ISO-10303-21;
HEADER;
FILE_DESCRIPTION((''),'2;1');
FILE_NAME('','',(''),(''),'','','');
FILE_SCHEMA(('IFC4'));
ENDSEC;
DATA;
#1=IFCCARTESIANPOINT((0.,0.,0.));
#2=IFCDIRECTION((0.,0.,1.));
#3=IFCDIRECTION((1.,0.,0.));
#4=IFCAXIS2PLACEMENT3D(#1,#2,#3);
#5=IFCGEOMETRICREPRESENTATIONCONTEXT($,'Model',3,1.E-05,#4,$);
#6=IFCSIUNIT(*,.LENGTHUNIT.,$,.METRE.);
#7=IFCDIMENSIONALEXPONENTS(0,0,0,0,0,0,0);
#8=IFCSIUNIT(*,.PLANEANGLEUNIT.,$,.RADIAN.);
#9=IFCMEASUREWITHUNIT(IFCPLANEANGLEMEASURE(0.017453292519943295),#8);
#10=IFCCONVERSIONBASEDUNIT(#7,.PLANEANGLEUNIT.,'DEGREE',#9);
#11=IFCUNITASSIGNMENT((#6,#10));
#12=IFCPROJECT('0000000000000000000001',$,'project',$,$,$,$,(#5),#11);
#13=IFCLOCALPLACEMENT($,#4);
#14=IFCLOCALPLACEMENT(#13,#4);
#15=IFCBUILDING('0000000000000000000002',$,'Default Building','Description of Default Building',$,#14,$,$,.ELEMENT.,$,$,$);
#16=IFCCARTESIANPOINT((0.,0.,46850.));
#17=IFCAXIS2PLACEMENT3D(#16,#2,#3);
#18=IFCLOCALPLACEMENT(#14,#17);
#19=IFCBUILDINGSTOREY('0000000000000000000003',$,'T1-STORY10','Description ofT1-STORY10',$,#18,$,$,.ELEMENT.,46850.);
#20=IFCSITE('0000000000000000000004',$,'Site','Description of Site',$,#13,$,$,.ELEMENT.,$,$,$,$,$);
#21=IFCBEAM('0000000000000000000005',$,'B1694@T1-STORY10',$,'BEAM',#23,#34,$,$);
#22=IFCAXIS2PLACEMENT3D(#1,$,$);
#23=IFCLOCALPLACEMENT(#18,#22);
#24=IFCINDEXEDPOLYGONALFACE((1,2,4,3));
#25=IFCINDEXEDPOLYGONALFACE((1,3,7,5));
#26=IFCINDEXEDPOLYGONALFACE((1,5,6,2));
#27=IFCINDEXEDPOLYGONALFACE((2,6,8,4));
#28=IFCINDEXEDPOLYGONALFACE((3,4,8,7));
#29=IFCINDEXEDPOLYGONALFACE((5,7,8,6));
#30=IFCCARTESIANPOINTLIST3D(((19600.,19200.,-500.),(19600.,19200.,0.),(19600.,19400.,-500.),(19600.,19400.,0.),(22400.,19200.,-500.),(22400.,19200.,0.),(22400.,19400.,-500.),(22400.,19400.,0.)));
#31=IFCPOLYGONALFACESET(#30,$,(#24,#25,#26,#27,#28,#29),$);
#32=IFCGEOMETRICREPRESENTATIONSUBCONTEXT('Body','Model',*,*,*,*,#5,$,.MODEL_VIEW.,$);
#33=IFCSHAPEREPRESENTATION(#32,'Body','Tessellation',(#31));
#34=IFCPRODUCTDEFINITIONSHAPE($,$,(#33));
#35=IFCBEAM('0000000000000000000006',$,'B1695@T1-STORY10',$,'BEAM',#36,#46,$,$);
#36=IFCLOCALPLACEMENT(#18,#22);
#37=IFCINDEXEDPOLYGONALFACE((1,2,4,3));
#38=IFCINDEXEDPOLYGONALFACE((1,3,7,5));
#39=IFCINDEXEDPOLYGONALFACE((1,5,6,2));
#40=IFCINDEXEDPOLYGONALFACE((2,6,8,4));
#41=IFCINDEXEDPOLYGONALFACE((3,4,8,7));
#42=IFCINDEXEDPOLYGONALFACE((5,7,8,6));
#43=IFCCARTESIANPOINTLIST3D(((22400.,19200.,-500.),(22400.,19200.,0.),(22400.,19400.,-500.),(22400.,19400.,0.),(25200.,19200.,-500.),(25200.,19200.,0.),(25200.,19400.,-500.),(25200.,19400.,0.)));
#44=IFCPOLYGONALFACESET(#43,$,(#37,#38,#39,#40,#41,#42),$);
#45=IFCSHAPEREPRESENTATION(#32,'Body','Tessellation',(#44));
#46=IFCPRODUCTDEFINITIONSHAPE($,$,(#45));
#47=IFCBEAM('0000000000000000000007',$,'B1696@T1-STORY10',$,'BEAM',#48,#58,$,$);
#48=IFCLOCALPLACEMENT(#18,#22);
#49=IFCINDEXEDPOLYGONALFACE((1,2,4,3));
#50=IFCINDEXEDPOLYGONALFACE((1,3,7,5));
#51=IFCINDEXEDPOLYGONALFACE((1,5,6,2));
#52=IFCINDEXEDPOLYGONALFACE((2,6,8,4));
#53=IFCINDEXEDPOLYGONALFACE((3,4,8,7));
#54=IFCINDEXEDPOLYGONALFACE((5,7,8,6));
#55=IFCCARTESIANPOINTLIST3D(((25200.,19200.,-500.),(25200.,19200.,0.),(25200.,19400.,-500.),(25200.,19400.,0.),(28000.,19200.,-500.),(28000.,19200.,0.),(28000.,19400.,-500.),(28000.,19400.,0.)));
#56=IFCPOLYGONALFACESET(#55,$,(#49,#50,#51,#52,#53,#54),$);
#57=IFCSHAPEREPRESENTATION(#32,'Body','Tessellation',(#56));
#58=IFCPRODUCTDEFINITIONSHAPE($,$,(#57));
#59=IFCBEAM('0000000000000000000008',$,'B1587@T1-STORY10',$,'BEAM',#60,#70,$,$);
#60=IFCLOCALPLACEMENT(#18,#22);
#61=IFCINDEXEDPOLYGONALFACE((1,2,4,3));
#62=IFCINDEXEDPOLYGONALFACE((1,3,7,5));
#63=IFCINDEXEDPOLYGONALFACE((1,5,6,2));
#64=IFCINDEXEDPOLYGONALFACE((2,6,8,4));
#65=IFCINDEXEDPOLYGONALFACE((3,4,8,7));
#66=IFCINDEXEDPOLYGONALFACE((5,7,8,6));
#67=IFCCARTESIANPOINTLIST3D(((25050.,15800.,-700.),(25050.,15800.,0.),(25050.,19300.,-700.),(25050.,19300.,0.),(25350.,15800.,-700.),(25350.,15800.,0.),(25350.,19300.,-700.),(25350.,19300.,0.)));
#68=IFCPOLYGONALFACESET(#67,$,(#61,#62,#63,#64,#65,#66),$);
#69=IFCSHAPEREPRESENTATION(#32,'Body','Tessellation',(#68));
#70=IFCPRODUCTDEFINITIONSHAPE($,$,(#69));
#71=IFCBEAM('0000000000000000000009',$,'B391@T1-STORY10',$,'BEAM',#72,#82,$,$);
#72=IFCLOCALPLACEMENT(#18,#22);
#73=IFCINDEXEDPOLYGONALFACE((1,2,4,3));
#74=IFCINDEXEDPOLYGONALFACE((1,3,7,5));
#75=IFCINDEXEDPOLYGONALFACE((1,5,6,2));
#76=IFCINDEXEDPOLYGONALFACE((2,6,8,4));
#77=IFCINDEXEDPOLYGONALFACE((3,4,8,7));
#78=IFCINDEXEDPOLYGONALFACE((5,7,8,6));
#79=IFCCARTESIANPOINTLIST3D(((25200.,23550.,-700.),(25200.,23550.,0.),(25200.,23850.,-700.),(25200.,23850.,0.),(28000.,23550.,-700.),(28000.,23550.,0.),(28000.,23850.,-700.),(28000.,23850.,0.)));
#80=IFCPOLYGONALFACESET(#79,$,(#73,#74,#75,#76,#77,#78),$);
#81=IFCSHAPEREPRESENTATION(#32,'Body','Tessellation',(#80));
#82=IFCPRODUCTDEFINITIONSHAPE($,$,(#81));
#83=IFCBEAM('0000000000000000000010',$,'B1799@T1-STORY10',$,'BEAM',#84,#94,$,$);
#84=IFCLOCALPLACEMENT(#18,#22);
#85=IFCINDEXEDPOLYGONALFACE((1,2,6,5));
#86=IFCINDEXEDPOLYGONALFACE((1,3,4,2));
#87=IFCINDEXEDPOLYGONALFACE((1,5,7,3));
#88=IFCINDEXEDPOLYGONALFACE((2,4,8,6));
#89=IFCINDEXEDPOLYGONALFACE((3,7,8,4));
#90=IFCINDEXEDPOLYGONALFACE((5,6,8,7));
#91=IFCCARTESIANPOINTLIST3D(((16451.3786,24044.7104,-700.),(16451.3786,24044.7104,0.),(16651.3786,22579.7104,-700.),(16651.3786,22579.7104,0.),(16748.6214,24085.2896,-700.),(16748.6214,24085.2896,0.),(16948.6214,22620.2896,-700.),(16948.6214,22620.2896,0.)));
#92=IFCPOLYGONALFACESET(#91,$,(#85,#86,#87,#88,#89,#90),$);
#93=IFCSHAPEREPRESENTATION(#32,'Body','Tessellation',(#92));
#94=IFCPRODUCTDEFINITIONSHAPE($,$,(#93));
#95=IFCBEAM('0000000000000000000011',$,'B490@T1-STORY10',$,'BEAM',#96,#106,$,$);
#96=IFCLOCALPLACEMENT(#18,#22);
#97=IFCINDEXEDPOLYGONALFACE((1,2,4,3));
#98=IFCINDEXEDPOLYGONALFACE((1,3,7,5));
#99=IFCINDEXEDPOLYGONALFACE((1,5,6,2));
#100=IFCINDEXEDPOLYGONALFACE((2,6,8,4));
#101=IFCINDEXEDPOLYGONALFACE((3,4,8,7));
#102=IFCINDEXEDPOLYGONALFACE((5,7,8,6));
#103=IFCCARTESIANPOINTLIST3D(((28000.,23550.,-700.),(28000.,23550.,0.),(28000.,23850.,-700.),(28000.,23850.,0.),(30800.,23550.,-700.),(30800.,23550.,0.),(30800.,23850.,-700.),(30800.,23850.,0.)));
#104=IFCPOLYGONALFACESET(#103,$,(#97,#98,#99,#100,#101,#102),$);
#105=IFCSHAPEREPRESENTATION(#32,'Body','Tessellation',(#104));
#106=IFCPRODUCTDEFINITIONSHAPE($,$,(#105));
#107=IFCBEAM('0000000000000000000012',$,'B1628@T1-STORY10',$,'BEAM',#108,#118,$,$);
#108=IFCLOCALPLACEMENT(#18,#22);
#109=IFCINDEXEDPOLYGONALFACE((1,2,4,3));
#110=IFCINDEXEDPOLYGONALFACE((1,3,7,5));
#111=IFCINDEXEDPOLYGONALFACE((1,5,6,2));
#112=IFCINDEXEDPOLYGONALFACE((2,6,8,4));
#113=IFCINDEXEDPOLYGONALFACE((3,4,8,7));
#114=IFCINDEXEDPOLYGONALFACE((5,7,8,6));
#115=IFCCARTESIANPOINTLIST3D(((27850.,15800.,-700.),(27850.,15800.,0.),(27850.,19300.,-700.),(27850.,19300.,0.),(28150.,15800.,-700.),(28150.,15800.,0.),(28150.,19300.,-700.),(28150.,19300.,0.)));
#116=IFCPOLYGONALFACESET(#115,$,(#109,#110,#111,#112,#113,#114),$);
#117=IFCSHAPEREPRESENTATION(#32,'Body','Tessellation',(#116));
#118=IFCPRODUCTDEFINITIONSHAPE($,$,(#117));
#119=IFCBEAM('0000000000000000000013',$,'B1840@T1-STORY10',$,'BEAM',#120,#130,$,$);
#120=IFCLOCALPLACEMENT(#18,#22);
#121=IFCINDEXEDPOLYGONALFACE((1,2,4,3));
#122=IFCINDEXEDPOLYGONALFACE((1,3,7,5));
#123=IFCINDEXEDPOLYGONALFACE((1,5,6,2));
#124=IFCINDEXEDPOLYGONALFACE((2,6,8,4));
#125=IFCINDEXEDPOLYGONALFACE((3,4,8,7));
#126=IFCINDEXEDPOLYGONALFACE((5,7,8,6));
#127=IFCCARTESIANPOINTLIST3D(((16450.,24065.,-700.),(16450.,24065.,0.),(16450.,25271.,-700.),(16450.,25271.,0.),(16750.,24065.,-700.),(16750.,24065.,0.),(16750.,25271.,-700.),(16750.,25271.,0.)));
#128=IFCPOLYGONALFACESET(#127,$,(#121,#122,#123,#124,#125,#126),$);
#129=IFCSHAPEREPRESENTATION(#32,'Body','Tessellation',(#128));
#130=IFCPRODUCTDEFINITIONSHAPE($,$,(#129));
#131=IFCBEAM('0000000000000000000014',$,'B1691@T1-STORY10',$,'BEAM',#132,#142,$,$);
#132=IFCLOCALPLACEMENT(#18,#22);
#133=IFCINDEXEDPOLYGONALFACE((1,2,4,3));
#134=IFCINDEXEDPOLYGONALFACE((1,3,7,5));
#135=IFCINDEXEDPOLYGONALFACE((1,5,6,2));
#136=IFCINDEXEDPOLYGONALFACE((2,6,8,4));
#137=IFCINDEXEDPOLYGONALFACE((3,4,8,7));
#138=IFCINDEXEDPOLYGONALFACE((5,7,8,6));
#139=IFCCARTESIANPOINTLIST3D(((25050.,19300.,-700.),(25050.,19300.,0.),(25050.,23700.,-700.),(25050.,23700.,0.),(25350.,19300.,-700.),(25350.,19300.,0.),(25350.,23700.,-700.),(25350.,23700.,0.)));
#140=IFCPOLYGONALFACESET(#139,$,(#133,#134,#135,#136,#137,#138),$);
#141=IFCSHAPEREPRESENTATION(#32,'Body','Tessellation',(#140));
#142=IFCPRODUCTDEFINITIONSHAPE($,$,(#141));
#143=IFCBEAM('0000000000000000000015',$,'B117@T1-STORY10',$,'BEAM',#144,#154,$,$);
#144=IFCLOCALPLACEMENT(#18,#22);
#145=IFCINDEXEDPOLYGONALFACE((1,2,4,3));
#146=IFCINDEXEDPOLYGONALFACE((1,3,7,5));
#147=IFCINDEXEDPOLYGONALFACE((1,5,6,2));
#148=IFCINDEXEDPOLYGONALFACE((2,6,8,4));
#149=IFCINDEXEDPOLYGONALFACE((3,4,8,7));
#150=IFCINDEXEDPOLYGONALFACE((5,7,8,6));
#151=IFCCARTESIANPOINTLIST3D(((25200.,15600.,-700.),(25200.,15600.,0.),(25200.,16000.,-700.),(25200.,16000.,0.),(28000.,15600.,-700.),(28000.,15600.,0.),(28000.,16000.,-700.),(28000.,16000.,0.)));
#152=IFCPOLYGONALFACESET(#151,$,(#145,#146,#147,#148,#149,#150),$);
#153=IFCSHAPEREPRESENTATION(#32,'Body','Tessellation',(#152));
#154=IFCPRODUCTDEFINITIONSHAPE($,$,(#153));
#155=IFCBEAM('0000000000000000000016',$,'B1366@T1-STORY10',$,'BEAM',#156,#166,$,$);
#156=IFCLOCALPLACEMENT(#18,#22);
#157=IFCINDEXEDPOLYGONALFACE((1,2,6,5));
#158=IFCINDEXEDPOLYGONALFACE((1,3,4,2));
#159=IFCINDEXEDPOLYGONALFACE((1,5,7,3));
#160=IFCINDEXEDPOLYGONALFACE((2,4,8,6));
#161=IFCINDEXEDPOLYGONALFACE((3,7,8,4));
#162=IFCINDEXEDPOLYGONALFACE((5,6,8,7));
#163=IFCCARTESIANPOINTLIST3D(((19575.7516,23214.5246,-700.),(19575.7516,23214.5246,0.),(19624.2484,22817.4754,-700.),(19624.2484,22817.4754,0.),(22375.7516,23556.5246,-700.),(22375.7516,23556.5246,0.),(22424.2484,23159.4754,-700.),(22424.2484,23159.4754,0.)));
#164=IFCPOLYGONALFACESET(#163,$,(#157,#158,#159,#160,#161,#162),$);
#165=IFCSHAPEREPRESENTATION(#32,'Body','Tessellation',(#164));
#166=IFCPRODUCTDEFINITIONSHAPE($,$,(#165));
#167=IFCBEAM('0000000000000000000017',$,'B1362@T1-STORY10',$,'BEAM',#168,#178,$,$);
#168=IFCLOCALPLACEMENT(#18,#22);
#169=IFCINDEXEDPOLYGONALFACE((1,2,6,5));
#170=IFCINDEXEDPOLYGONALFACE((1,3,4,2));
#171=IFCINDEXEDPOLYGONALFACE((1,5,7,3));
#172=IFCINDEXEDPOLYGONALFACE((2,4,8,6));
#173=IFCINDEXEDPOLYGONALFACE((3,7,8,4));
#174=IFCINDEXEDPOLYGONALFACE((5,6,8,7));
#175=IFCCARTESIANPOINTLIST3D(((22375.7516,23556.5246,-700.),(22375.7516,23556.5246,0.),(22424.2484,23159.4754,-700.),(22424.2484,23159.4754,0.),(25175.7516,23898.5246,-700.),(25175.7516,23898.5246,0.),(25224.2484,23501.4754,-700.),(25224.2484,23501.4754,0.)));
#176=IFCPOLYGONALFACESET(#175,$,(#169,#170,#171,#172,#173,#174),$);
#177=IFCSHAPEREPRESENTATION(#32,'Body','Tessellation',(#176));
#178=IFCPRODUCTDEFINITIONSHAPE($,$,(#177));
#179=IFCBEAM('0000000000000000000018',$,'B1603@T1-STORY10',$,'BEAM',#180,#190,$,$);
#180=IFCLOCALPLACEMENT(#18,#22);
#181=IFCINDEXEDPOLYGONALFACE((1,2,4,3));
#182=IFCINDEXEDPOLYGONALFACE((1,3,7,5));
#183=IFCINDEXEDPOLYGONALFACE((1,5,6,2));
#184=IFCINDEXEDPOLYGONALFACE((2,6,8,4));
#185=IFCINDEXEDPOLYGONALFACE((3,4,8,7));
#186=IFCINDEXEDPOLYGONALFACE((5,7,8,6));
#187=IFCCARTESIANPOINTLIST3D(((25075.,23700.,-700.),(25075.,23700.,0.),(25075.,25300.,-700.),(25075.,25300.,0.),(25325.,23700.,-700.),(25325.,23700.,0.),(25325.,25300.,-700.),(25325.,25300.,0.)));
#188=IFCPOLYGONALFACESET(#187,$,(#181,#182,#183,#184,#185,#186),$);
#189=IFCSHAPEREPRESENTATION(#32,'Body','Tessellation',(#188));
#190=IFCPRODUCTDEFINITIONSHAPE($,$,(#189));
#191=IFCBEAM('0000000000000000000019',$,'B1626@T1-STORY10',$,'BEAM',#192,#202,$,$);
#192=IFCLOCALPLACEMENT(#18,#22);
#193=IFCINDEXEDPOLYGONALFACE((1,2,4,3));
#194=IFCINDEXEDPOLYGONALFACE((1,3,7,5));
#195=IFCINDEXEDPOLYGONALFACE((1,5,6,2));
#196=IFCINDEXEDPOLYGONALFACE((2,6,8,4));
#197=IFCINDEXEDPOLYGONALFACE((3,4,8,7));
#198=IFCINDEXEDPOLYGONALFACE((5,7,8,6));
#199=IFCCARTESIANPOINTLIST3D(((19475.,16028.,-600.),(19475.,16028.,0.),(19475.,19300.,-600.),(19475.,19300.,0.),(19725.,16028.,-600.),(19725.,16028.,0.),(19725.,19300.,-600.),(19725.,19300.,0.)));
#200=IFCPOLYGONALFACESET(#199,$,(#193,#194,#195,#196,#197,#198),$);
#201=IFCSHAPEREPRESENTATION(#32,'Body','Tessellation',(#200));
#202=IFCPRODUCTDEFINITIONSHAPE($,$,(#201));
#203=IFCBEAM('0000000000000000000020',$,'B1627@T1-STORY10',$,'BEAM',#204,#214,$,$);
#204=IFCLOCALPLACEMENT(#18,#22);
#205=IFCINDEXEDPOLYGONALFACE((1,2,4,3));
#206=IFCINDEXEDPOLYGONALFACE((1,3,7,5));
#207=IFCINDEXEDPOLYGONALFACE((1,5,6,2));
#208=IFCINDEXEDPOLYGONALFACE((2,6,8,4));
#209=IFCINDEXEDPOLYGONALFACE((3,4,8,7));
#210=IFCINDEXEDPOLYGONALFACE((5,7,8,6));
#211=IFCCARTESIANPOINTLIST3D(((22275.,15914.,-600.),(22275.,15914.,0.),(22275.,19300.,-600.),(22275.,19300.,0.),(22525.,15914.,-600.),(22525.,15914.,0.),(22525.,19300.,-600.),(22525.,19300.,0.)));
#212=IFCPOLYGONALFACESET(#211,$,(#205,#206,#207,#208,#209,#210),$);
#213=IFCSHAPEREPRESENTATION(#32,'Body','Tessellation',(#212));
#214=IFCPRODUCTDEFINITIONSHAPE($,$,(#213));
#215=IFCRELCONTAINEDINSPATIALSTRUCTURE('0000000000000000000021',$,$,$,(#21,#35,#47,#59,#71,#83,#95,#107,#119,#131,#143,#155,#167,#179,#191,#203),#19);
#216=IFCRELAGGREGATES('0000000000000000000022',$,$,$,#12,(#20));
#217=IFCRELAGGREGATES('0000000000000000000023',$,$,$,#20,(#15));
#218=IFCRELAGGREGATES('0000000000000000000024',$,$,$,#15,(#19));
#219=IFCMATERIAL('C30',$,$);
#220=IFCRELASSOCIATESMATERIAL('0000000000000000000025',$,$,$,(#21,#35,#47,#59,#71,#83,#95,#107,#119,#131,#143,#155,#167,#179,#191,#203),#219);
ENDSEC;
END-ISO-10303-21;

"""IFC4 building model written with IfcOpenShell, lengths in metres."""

from ifc_helpers import new_model, entity, si_unit, converted_unit, frame, origin_with_axes, place, context, subcontext, project, spatial, rectangle, extrude, material, element, save


model = new_model("IFC4")

# Units and contexts
model_context = context("Model", 3, precision=1e-05, world=origin_with_axes())
body_context = subcontext(model_context, "Body", "Model", "MODEL_VIEW")
ifc_project = project(units=[si_unit("LENGTHUNIT", "METRE"), converted_unit("PLANEANGLEUNIT", "DEGREE", entity("IfcPlaneAngleMeasure", 0.017453292519943295), si_unit("PLANEANGLEUNIT", "RADIAN"), dimensions=[0, 0, 0, 0, 0, 0, 0])], contexts=[model_context])

# Site, building, storey
site_placement = place(None, origin_with_axes())
site = spatial("IfcSite", under=ifc_project, at=site_placement, Name="Site", Description="Description of Site", CompositionType="ELEMENT")
building_placement = place(site_placement, origin_with_axes())
building = spatial("IfcBuilding", under=site, at=building_placement, Name="Default Building", Description="Description of Default Building", CompositionType="ELEMENT")
storey_placement = place(building_placement, frame((0.0, 0.0, 46850.0), z_axis=(0.0, 0.0, 1.0), x_axis=(1.0, 0.0, 0.0)))
storey = spatial("IfcBuildingStorey", under=building, at=storey_placement, Name="T1-STORY10", Description="Description ofT1-STORY10", CompositionType="ELEMENT", Elevation=46850.0)

# Beams
ifc_material_1 = material(Name="C30")
for number, where, z_axis, x_axis, name in (
    (1, (19600.0, 19300.0, -250.0), (1.0, 0.0, 0.0), (0.0, 1.0, 0.0), "B1694@T1-STORY10"),
    (2, (22400.0, 19300.0, -250.0), (1.0, 0.0, 0.0), (0.0, 1.0, 0.0), "B1695@T1-STORY10"),
    (3, (25200.0, 19300.0, -250.0), (1.0, 0.0, 0.0), (0.0, 1.0, 0.0), "B1696@T1-STORY10"),
):
    element("IfcBeam", number, at=place(storey_placement, frame(where, z_axis=z_axis, x_axis=x_axis)), inside=storey, material=ifc_material_1, Name=name, ObjectType="BEAM", context=body_context, shape_type="SweptSolid", body=[
        extrude(rectangle(XDim=200.0, YDim=500.0), origin_with_axes(), (0.0, 0.0, 1.0), 2800.0),
    ])
beam_1_placement = place(storey_placement, frame((25200.0, 15800.0, -350.0), z_axis=(0.0, 1.0, 0.0), x_axis=(-1.0, 0.0, 0.0)))
element("IfcBeam", 4, at=beam_1_placement, inside=storey, material=ifc_material_1, Name="B1587@T1-STORY10", ObjectType="BEAM", context=body_context, shape_type="SweptSolid", body=[
    extrude(rectangle(XDim=300.0, YDim=700.0), origin_with_axes(), (0.0, 0.0, 1.0), 3500.0),
])
beam_2_placement = place(storey_placement, frame((25200.0, 23700.0, -350.0), z_axis=(1.0, 0.0, 0.0), x_axis=(0.0, 1.0, 0.0)))
element("IfcBeam", 5, at=beam_2_placement, inside=storey, material=ifc_material_1, Name="B391@T1-STORY10", ObjectType="BEAM", context=body_context, shape_type="SweptSolid", body=[
    extrude(rectangle(XDim=300.0, YDim=700.0), origin_with_axes(), (0.0, 0.0, 1.0), 2800.0),
])
beam_3_placement = place(storey_placement, frame((16800.0, 22600.0, -350.0), z_axis=(-0.135264, 0.99081, 0.0), x_axis=(-0.99081, -0.135264, 0.0)))
element("IfcBeam", 6, at=beam_3_placement, inside=storey, material=ifc_material_1, Name="B1799@T1-STORY10", ObjectType="BEAM", context=body_context, shape_type="SweptSolid", body=[
    extrude(rectangle(XDim=300.0, YDim=700.0), origin_with_axes(), (0.0, 0.0, 1.0), 1478.5889),
])
beam_4_placement = place(storey_placement, frame((28000.0, 23700.0, -350.0), z_axis=(1.0, 0.0, 0.0), x_axis=(0.0, 1.0, 0.0)))
element("IfcBeam", 7, at=beam_4_placement, inside=storey, material=ifc_material_1, Name="B490@T1-STORY10", ObjectType="BEAM", context=body_context, shape_type="SweptSolid", body=[
    extrude(rectangle(XDim=300.0, YDim=700.0), origin_with_axes(), (0.0, 0.0, 1.0), 2800.0),
])
beam_5_placement = place(storey_placement, frame((28000.0, 15800.0, -350.0), z_axis=(0.0, 1.0, 0.0), x_axis=(-1.0, 0.0, 0.0)))
element("IfcBeam", 8, at=beam_5_placement, inside=storey, material=ifc_material_1, Name="B1628@T1-STORY10", ObjectType="BEAM", context=body_context, shape_type="SweptSolid", body=[
    extrude(rectangle(XDim=300.0, YDim=700.0), origin_with_axes(), (0.0, 0.0, 1.0), 3500.0),
])
beam_6_placement = place(storey_placement, frame((16600.0, 24065.0, -350.0), z_axis=(0.0, 1.0, 0.0), x_axis=(-1.0, 0.0, 0.0)))
element("IfcBeam", 9, at=beam_6_placement, inside=storey, material=ifc_material_1, Name="B1840@T1-STORY10", ObjectType="BEAM", context=body_context, shape_type="SweptSolid", body=[
    extrude(rectangle(XDim=300.0, YDim=700.0), origin_with_axes(), (0.0, 0.0, 1.0), 1206.0),
])
beam_7_placement = place(storey_placement, frame((25200.0, 19300.0, -350.0), z_axis=(0.0, 1.0, 0.0), x_axis=(-1.0, 0.0, 0.0)))
element("IfcBeam", 10, at=beam_7_placement, inside=storey, material=ifc_material_1, Name="B1691@T1-STORY10", ObjectType="BEAM", context=body_context, shape_type="SweptSolid", body=[
    extrude(rectangle(XDim=300.0, YDim=700.0), origin_with_axes(), (0.0, 0.0, 1.0), 4400.0),
])
beam_8_placement = place(storey_placement, frame((25200.0, 15800.0, -350.0), z_axis=(1.0, 0.0, 0.0), x_axis=(0.0, 1.0, 0.0)))
element("IfcBeam", 11, at=beam_8_placement, inside=storey, material=ifc_material_1, Name="B117@T1-STORY10", ObjectType="BEAM", context=body_context, shape_type="SweptSolid", body=[
    extrude(rectangle(XDim=400.0, YDim=700.0), origin_with_axes(), (0.0, 0.0, 1.0), 2800.0),
])
for number, where, z_axis, x_axis, name in (
    (12, (19600.0, 23016.0, -350.0), (0.992623, 0.121242, 0.0), (-0.121242, 0.992623, 0.0), "B1366@T1-STORY10"),
    (13, (22400.0, 23358.0, -350.0), (0.992623, 0.121242, 0.0), (-0.121242, 0.992623, 0.0), "B1362@T1-STORY10"),
):
    element("IfcBeam", number, at=place(storey_placement, frame(where, z_axis=z_axis, x_axis=x_axis)), inside=storey, material=ifc_material_1, Name=name, ObjectType="BEAM", context=body_context, shape_type="SweptSolid", body=[
        extrude(rectangle(XDim=400.0, YDim=700.0), origin_with_axes(), (0.0, 0.0, 1.0), 2820.8091),
    ])
beam_9_placement = place(storey_placement, frame((25200.0, 23700.0, -350.0), z_axis=(0.0, 1.0, 0.0), x_axis=(-1.0, 0.0, 0.0)))
element("IfcBeam", 14, at=beam_9_placement, inside=storey, material=ifc_material_1, Name="B1603@T1-STORY10", ObjectType="BEAM", context=body_context, shape_type="SweptSolid", body=[
    extrude(rectangle(XDim=250.0, YDim=700.0), origin_with_axes(), (0.0, 0.0, 1.0), 1600.0),
])
beam_10_placement = place(storey_placement, frame((19600.0, 16028.0, -300.0), z_axis=(0.0, 1.0, 0.0), x_axis=(-1.0, 0.0, 0.0)))
element("IfcBeam", 15, at=beam_10_placement, inside=storey, material=ifc_material_1, Name="B1626@T1-STORY10", ObjectType="BEAM", context=body_context, shape_type="SweptSolid", body=[
    extrude(rectangle(XDim=250.0, YDim=600.0), origin_with_axes(), (0.0, 0.0, 1.0), 3272.0),
])
beam_11_placement = place(storey_placement, frame((22400.0, 15914.0, -300.0), z_axis=(0.0, 1.0, 0.0), x_axis=(-1.0, 0.0, 0.0)))
element("IfcBeam", 16, at=beam_11_placement, inside=storey, material=ifc_material_1, Name="B1627@T1-STORY10", ObjectType="BEAM", context=body_context, shape_type="SweptSolid", body=[
    extrude(rectangle(XDim=250.0, YDim=600.0), origin_with_axes(), (0.0, 0.0, 1.0), 3386.0),
])

save(model, "model.ifc")
